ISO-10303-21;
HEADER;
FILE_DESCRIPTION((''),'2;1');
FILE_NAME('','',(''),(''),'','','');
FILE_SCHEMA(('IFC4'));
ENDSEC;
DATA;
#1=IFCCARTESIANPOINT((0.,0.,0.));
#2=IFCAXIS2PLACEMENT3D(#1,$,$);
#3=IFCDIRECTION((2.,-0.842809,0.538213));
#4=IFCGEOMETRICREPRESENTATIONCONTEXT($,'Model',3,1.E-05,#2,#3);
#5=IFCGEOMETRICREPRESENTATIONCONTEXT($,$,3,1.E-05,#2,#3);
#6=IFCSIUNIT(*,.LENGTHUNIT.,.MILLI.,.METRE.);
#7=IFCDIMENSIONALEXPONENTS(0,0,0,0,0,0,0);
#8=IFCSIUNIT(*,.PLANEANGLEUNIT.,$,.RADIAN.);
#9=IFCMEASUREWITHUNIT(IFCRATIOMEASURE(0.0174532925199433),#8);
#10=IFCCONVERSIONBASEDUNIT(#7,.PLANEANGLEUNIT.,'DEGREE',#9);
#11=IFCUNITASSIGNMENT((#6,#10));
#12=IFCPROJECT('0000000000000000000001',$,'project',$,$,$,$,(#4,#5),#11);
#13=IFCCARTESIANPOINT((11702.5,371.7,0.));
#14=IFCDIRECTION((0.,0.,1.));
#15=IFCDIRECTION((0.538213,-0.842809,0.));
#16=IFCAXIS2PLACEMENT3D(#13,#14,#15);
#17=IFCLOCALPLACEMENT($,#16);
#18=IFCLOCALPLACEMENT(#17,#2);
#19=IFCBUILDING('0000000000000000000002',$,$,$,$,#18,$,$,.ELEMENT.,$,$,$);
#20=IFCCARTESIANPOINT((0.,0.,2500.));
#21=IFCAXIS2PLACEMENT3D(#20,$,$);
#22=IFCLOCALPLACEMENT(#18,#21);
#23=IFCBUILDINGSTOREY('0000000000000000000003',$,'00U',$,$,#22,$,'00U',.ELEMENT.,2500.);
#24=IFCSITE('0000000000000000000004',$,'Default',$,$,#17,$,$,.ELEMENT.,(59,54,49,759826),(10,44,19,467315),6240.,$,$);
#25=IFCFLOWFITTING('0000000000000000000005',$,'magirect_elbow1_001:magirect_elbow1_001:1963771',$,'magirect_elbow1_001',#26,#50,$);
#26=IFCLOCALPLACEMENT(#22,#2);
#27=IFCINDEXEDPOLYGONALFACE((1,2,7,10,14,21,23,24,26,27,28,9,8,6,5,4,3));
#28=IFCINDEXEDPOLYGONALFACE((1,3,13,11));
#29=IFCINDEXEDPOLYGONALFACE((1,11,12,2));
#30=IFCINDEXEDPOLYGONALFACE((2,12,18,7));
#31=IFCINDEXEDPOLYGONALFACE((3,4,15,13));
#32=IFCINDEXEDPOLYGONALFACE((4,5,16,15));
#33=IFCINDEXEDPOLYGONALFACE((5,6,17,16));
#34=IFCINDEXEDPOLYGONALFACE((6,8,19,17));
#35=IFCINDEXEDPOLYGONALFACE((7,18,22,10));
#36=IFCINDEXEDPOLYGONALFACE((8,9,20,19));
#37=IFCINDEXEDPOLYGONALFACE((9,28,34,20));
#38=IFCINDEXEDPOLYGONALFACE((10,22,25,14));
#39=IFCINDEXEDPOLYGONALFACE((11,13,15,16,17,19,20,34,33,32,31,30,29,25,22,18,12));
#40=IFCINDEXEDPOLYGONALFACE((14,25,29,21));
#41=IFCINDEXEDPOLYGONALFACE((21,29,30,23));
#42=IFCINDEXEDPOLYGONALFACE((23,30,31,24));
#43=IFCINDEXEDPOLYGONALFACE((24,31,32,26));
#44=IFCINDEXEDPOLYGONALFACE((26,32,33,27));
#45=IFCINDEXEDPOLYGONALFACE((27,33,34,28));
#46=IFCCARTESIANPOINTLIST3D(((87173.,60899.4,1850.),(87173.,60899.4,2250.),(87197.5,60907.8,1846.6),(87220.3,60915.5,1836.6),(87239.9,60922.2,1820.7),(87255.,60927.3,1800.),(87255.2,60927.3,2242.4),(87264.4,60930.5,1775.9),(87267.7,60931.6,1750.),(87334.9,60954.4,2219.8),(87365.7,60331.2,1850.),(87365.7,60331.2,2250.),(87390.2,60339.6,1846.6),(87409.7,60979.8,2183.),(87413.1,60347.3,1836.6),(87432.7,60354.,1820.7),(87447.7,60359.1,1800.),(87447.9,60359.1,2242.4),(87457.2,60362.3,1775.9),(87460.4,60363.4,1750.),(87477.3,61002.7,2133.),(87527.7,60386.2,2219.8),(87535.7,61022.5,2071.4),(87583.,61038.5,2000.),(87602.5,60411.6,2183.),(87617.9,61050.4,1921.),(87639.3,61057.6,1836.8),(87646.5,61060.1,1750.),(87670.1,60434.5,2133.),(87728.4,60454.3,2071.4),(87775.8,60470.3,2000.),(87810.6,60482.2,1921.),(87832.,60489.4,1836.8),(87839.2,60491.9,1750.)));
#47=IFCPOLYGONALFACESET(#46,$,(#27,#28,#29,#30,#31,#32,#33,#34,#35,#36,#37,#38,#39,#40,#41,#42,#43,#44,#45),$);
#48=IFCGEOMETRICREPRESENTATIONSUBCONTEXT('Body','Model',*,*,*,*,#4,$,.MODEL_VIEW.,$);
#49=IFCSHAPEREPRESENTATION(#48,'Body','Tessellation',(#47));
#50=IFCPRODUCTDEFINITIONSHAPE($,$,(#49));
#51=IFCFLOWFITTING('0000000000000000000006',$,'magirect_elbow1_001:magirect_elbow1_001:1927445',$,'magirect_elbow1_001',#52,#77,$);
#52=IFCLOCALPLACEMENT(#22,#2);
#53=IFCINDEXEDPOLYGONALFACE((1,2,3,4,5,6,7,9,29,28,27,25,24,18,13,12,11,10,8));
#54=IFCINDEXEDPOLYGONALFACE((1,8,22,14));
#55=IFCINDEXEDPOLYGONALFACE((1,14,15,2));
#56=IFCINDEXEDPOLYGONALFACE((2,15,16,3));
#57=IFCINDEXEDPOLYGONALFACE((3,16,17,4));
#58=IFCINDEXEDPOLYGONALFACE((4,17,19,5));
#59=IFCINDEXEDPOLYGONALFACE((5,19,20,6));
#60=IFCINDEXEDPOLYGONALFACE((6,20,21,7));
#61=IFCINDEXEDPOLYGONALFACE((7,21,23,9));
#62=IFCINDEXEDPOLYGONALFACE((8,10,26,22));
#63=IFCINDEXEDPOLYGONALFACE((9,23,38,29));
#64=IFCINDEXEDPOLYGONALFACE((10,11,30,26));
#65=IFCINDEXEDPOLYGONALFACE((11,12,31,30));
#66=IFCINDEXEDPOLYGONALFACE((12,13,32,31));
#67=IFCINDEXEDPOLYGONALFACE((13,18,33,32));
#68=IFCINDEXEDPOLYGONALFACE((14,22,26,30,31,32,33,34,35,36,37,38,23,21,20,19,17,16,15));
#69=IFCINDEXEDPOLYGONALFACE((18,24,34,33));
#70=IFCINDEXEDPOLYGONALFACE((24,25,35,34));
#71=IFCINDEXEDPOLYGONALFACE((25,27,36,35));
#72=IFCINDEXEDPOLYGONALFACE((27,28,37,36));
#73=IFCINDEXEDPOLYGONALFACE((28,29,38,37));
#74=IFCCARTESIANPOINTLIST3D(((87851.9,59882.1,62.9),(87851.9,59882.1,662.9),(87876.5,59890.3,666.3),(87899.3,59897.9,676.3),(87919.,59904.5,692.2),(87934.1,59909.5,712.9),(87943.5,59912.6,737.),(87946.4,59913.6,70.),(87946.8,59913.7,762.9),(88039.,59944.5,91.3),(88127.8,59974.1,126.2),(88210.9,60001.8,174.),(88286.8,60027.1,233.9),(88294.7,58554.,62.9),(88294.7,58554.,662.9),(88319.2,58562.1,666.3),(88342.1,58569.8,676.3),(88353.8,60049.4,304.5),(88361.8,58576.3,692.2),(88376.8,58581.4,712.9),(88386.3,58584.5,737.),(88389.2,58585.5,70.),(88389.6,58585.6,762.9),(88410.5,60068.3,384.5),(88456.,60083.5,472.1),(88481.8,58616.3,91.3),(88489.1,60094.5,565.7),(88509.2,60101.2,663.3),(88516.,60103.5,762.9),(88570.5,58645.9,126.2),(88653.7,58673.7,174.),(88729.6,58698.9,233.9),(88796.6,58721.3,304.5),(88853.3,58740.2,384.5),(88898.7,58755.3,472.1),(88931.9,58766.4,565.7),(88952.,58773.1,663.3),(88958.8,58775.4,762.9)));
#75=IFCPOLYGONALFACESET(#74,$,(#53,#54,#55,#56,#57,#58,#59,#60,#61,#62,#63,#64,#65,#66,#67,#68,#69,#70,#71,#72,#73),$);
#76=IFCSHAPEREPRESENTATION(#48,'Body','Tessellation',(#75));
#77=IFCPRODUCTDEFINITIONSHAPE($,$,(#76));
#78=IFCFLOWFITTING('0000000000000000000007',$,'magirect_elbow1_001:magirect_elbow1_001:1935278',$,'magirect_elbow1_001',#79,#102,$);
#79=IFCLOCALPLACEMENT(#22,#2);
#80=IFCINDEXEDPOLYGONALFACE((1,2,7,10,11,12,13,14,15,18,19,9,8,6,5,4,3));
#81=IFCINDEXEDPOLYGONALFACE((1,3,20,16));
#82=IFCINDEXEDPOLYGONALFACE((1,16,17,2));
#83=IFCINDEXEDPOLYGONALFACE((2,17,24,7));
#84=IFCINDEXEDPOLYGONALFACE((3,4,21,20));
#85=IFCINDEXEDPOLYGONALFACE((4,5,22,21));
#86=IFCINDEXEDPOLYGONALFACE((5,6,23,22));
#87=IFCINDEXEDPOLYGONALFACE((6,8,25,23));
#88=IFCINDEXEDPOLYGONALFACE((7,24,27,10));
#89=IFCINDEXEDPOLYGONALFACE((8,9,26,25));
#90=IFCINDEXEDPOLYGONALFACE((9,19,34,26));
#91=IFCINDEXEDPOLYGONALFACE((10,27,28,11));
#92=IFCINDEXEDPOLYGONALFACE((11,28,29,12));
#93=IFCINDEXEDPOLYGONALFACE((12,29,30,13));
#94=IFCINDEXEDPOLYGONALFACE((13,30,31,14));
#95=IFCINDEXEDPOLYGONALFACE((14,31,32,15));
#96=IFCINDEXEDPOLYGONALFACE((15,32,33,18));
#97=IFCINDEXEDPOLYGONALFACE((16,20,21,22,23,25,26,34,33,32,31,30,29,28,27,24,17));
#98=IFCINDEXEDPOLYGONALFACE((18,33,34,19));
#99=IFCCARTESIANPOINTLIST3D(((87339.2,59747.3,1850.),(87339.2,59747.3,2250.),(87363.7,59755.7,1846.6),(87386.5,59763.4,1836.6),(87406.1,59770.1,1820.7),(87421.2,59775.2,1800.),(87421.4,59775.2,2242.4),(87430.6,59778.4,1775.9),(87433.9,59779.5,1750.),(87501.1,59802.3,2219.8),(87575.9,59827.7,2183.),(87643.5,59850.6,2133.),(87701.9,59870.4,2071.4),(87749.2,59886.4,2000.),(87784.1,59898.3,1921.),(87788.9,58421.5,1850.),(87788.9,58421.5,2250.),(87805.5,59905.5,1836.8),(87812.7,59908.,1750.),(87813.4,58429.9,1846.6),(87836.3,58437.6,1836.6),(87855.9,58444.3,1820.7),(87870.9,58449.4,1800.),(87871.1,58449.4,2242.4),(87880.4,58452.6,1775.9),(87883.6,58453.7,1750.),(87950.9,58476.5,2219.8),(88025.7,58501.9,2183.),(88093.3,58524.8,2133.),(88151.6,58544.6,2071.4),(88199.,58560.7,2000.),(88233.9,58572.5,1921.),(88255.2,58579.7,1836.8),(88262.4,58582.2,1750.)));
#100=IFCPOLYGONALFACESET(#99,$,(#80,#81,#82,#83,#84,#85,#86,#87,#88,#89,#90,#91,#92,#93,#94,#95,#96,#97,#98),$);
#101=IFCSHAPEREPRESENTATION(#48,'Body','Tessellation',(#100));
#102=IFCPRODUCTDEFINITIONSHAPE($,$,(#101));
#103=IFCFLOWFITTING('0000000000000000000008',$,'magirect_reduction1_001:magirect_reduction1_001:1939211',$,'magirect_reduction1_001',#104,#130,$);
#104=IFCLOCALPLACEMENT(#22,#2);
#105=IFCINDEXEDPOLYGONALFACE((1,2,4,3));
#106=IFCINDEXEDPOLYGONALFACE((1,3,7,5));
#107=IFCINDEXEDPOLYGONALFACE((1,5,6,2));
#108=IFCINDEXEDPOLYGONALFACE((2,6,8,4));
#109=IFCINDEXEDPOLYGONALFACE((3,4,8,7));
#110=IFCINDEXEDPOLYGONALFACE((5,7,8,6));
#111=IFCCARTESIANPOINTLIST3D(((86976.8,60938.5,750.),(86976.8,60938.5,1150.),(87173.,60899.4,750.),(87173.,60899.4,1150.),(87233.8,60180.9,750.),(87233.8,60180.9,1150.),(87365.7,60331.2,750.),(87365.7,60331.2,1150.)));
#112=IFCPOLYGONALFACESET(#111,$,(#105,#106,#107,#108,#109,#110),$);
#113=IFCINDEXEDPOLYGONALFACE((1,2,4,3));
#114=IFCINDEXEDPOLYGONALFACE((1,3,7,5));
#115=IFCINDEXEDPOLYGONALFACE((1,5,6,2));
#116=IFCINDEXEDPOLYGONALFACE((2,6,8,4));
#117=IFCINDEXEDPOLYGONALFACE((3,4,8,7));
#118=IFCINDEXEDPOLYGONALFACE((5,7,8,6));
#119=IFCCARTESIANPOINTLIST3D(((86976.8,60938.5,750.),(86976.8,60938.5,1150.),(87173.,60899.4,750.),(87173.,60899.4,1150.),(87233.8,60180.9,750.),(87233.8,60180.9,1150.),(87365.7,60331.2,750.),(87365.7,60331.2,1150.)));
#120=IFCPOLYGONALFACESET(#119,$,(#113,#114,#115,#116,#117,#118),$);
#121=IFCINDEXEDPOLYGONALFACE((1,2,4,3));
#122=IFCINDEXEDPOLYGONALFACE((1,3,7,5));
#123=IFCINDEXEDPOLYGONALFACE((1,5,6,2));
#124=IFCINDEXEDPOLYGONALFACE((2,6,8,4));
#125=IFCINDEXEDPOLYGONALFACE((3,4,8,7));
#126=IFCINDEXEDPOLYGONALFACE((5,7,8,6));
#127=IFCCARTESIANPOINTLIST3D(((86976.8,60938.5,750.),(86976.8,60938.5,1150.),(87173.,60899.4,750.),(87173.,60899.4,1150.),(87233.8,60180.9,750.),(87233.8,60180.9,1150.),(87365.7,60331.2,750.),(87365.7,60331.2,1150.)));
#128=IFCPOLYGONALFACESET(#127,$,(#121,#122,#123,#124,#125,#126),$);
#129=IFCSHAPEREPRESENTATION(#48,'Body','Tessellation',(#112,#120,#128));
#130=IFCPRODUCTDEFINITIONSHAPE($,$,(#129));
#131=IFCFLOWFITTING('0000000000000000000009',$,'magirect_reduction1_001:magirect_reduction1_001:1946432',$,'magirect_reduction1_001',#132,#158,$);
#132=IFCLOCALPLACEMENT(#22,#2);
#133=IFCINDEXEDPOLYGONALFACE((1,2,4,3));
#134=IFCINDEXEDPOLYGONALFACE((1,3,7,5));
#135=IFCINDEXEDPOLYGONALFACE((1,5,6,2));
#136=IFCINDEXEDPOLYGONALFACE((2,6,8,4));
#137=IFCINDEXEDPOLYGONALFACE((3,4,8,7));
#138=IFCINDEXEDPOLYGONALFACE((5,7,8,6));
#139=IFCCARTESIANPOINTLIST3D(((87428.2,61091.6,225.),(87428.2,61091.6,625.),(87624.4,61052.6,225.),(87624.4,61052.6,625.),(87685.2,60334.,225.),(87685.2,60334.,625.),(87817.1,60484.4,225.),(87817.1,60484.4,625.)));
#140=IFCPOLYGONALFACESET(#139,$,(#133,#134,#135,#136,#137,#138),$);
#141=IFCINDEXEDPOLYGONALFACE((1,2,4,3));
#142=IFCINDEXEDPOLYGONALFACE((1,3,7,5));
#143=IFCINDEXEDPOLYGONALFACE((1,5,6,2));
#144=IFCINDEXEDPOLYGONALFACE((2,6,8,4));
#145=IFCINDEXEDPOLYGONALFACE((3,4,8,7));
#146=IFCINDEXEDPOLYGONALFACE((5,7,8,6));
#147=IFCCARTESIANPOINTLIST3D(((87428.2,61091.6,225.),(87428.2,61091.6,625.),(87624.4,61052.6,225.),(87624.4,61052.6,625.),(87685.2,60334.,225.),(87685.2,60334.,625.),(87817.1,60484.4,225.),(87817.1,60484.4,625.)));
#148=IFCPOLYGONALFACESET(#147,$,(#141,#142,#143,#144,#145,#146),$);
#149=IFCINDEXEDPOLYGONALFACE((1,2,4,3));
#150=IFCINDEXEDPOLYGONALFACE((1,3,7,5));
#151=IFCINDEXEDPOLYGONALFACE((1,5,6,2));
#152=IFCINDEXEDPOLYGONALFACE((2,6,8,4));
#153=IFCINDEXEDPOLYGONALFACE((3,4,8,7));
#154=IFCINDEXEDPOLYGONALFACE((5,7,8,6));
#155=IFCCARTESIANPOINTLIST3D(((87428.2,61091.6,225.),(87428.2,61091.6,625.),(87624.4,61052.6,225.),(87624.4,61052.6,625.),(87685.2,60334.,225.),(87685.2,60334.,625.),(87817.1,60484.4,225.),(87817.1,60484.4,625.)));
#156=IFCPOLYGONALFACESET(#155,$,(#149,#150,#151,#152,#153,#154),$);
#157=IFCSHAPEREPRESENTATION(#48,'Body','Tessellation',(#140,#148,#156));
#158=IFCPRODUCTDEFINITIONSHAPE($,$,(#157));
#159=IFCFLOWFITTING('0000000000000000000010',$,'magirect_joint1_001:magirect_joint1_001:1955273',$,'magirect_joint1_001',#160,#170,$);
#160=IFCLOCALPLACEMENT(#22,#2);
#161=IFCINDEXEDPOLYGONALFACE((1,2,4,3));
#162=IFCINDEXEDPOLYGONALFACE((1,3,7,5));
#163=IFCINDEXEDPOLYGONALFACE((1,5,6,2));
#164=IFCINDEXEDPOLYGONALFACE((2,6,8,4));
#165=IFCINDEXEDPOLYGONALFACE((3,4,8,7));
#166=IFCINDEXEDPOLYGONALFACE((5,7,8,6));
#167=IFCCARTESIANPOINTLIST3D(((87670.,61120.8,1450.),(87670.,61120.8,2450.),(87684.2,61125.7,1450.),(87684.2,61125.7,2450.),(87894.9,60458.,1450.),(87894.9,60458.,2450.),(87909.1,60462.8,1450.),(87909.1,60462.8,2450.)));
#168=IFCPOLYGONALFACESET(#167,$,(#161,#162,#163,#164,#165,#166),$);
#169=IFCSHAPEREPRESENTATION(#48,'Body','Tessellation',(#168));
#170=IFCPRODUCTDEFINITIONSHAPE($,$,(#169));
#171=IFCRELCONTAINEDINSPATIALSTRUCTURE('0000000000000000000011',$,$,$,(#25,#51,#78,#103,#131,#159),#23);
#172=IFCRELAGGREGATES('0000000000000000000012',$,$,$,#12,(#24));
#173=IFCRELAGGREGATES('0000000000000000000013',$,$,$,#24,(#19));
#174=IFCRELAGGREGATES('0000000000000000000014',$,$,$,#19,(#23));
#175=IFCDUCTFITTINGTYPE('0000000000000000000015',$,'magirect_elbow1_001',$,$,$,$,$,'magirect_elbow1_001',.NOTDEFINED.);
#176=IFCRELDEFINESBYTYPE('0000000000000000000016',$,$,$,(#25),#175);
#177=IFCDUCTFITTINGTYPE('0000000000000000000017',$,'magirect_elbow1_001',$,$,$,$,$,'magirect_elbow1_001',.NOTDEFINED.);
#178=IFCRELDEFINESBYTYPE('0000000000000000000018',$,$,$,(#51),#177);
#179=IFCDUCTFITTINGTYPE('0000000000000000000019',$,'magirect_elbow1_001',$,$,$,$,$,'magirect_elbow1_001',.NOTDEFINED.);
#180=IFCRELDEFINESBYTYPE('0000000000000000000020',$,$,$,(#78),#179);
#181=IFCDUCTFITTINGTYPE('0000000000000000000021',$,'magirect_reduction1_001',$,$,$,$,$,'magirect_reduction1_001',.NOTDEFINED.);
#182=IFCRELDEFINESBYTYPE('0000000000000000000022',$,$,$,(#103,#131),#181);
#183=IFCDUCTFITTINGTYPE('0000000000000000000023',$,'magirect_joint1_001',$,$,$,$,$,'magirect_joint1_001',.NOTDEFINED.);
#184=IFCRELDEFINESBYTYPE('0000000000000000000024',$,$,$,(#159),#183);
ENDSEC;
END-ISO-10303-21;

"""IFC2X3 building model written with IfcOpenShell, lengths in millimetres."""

from ifc_helpers import new_model, entity, si_unit, converted_unit, direction, frame, frame_2d, origin, place, context, subcontext, project, spatial, polyline, circle_curve, parameter, trimmed, segment, composite_curve, rectangle, outline, extrude, source, transform, mapped, type_object, type_shapes, element, save


model = new_model("IFC2X3")

# Units and contexts
model_context = context("Model", 3, precision=1e-05, world=origin(), true_north=direction((2.0, -0.842809, 0.538213)))
context_of_model = context(None, 3, precision=1e-05, world=origin(), true_north=direction((2.0, -0.842809, 0.538213)))
body_context = subcontext(model_context, "Body", "Model", "MODEL_VIEW")
ifc_project = project(units=[si_unit("LENGTHUNIT", "METRE", prefix="MILLI"), converted_unit("PLANEANGLEUNIT", "DEGREE", entity("IfcRatioMeasure", 0.0174532925199433), si_unit("PLANEANGLEUNIT", "RADIAN"), dimensions=[0, 0, 0, 0, 0, 0, 0])], contexts=[model_context, context_of_model])

# Site, building, storey
site_placement = place(None, frame((11702.5, 371.7, 0.0), z_axis=(0.0, 0.0, 1.0), x_axis=(0.538213, -0.842809, 0.0)))
site = spatial("IfcSite", under=ifc_project, at=site_placement, Name="Default", CompositionType="ELEMENT", RefLatitude=(59, 54, 49, 759826), RefLongitude=(10, 44, 19, 467315), RefElevation=6240.0)
building_placement = place(site_placement, origin())
building = spatial("IfcBuilding", under=site, at=building_placement, CompositionType="ELEMENT")
storey_placement = place(building_placement, frame((0.0, 0.0, 2500.0)))
storey = spatial("IfcBuildingStorey", under=building, at=storey_placement, Name="00U", LongName="00U", CompositionType="ELEMENT", Elevation=2500.0)

# Flow fittings
duct_fitting_type_1 = type_object("IfcDuctFittingType", Name="magirect_elbow1_001", ElementType="magirect_elbow1_001", PredefinedType="NOTDEFINED")
shared_shape_1 = source(origin(), body_context, "Body", "SweptSolid", [
    extrude(outline(composite_curve([segment(polyline([(-350.0, -150.0), (50.0, -150.0)]), True, "CONTINUOUS"), segment(trimmed(circle_curve(frame_2d((150.0, -150.0), x_axis=(0.0, 1.0)), 100.0), [parameter(0.0)], [parameter(90.0)], True, "PARAMETER"), False, "CONTINUOUS"), segment(polyline([(150.0, -50.0), (150.0, 350.0)]), True, "CONTINUOUS"), segment(trimmed(circle_curve(frame_2d((150.0, -150.0), x_axis=(0.0, 1.0)), 500.0), [parameter(0.0)], [parameter(90.0)], True, "PARAMETER"), True, "CONTINUOUS")], self_intersect=False)), frame((-150.0, 150.0, -300.0), z_axis=(0.0, 0.0, 1.0), x_axis=(-1.0, 0.0, 0.0)), (0.0, 0.0, 1.0), 600.0),
])
type_shapes(duct_fitting_type_1, [shared_shape_1])
for number, where, z_axis, x_axis, name in (
    (1, (87553.4, 60711.7, 2050.0), (0.321246, -0.946996, 0.0), (0.0, 0.0, 1.0), "magirect_elbow1_001:magirect_elbow1_001:1963771"),
):
    element("IfcFlowFitting", number, at=place(storey_placement, frame(where, z_axis=z_axis, x_axis=x_axis)), inside=storey, type_object=duct_fitting_type_1, Name=name, ObjectType="magirect_elbow1_001", context=body_context, shape_type="MappedRepresentation", body=[
        mapped(shared_shape_1, transform((0.0, 0.0, 0.0), scale=1.0)),
    ])
duct_fitting_type_2 = type_object("IfcDuctFittingType", Name="magirect_elbow1_001", ElementType="magirect_elbow1_001", PredefinedType="NOTDEFINED")
shared_shape_2 = source(origin(), body_context, "Body", "SweptSolid", [
    extrude(outline(composite_curve([segment(polyline([(-500.0, -200.0), (100.0, -200.0)]), True, "CONTINUOUS"), segment(trimmed(circle_curve(frame_2d((200.0, -200.0), x_axis=(0.0, 1.0)), 100.0), [parameter(0.0)], [parameter(90.0)], True, "PARAMETER"), False, "CONTINUOUS"), segment(polyline([(200.0, -100.0), (200.0, 500.0)]), True, "CONTINUOUS"), segment(trimmed(circle_curve(frame_2d((200.0, -200.0), x_axis=(0.0, 1.0)), 700.0), [parameter(0.0)], [parameter(90.0)], True, "PARAMETER"), True, "CONTINUOUS")], self_intersect=False)), frame((-200.0, 200.0, -700.0), z_axis=(0.0, 0.0, 1.0), x_axis=(-1.0, 0.0, 0.0)), (0.0, 0.0, 1.0), 1400.0),
])
type_shapes(duct_fitting_type_2, [shared_shape_2])
flow_fitting_1_placement = place(storey_placement, frame((88452.8, 59344.5, 362.9), z_axis=(0.316277, -0.948667, 0.0), x_axis=(0.948667, 0.316277, 0.0)))
element("IfcFlowFitting", 2, at=flow_fitting_1_placement, inside=storey, type_object=duct_fitting_type_2, Name="magirect_elbow1_001:magirect_elbow1_001:1927445", ObjectType="magirect_elbow1_001", context=body_context, shape_type="MappedRepresentation", body=[
    mapped(shared_shape_2, transform((0.0, 0.0, 0.0), scale=1.0)),
])
duct_fitting_type_3 = type_object("IfcDuctFittingType", Name="magirect_elbow1_001", ElementType="magirect_elbow1_001", PredefinedType="NOTDEFINED")
shared_shape_3 = source(origin(), body_context, "Body", "SweptSolid", [
    extrude(outline(composite_curve([segment(polyline([(-350.0, -150.0), (50.0, -150.0)]), True, "CONTINUOUS"), segment(trimmed(circle_curve(frame_2d((150.0, -150.0), x_axis=(0.0, 1.0)), 100.0), [parameter(0.0)], [parameter(90.0)], True, "PARAMETER"), False, "CONTINUOUS"), segment(polyline([(150.0, -50.0), (150.0, 350.0)]), True, "CONTINUOUS"), segment(trimmed(circle_curve(frame_2d((150.0, -150.0), x_axis=(0.0, 1.0)), 500.0), [parameter(0.0)], [parameter(90.0)], True, "PARAMETER"), True, "CONTINUOUS")], self_intersect=False)), frame((-150.0, 150.0, -700.0), z_axis=(0.0, 0.0, 1.0), x_axis=(-1.0, 0.0, 0.0)), (0.0, 0.0, 1.0), 1400.0),
])
type_shapes(duct_fitting_type_3, [shared_shape_3])
flow_fitting_2_placement = place(storey_placement, frame((87848.1, 59180.8, 2050.0), z_axis=(-0.321246, 0.946996, 0.0), x_axis=(0.946996, 0.321246, 0.0)))
element("IfcFlowFitting", 3, at=flow_fitting_2_placement, inside=storey, type_object=duct_fitting_type_3, Name="magirect_elbow1_001:magirect_elbow1_001:1935278", ObjectType="magirect_elbow1_001", context=body_context, shape_type="MappedRepresentation", body=[
    mapped(shared_shape_3, transform((0.0, 0.0, 0.0), scale=1.0)),
])
duct_fitting_type_4 = type_object("IfcDuctFittingType", Name="magirect_reduction1_001", ElementType="magirect_reduction1_001", PredefinedType="NOTDEFINED")
shared_shape_4 = source(origin(), body_context, "Body", "SweptSolid", [
    extrude(outline(polyline([(-300.0, -86.6), (300.0, -86.6), (400.0, 86.6), (-400.0, 86.6), (-300.0, -86.6)])), frame((86.6, 0.0, -200.0), z_axis=(0.0, 0.0, 1.0), x_axis=(0.0, -1.0, 0.0)), (0.0, 0.0, 1.0), 400.0),
    extrude(outline(polyline([(-300.0, -86.6), (300.0, -86.6), (400.0, 86.6), (-400.0, 86.6), (-300.0, -86.6)])), frame((86.6, 0.0, -200.0), z_axis=(0.0, 0.0, 1.0), x_axis=(0.0, -1.0, 0.0)), (0.0, 0.0, 1.0), 400.0),
    extrude(outline(polyline([(-300.0, -86.6), (300.0, -86.6), (400.0, 86.6), (-400.0, 86.6), (-300.0, -86.6)])), frame((86.6, 0.0, -200.0), z_axis=(0.0, 0.0, 1.0), x_axis=(0.0, -1.0, 0.0)), (0.0, 0.0, 1.0), 400.0),
])
type_shapes(duct_fitting_type_4, [shared_shape_4])
for number, where, z_axis, x_axis, name in (
    (4, (87269.3, 60615.3, 950.0), (0.0, 0.0, 1.0), (-0.946996, -0.321246, 0.0), "magirect_reduction1_001:magirect_reduction1_001:1939211"),
    (5, (87720.7, 60768.5, 425.0), (0.0, 0.0, 1.0), (-0.946996, -0.321246, 0.0), "magirect_reduction1_001:magirect_reduction1_001:1946432"),
):
    element("IfcFlowFitting", number, at=place(storey_placement, frame(where, z_axis=z_axis, x_axis=x_axis)), inside=storey, type_object=duct_fitting_type_4, Name=name, ObjectType="magirect_reduction1_001", context=body_context, shape_type="MappedRepresentation", body=[
        mapped(shared_shape_4, transform((0.0, 0.0, 0.0), scale=1.0)),
    ])
duct_fitting_type_5 = type_object("IfcDuctFittingType", Name="magirect_joint1_001", ElementType="magirect_joint1_001", PredefinedType="NOTDEFINED")
shared_shape_5 = source(origin(), body_context, "Body", "SweptSolid", [
    extrude(rectangle(XDim=15.0, YDim=700.0, at=frame_2d((0.0, 0.0), x_axis=(1.0, 0.0))), frame((7.5, 0.0, -500.0)), (0.0, 0.0, 1.0), 1000.0),
])
type_shapes(duct_fitting_type_5, [shared_shape_5])
flow_fitting_3_placement = place(storey_placement, frame((87796.6, 60794.2, 1950.0), z_axis=(0.0, 0.0, 1.0), x_axis=(-0.946996, -0.321246, 0.0)))
element("IfcFlowFitting", 6, at=flow_fitting_3_placement, inside=storey, type_object=duct_fitting_type_5, Name="magirect_joint1_001:magirect_joint1_001:1955273", ObjectType="magirect_joint1_001", context=body_context, shape_type="MappedRepresentation", body=[
    mapped(shared_shape_5, transform((0.0, 0.0, 0.0), scale=1.0)),
])

save(model, "model.ifc")
